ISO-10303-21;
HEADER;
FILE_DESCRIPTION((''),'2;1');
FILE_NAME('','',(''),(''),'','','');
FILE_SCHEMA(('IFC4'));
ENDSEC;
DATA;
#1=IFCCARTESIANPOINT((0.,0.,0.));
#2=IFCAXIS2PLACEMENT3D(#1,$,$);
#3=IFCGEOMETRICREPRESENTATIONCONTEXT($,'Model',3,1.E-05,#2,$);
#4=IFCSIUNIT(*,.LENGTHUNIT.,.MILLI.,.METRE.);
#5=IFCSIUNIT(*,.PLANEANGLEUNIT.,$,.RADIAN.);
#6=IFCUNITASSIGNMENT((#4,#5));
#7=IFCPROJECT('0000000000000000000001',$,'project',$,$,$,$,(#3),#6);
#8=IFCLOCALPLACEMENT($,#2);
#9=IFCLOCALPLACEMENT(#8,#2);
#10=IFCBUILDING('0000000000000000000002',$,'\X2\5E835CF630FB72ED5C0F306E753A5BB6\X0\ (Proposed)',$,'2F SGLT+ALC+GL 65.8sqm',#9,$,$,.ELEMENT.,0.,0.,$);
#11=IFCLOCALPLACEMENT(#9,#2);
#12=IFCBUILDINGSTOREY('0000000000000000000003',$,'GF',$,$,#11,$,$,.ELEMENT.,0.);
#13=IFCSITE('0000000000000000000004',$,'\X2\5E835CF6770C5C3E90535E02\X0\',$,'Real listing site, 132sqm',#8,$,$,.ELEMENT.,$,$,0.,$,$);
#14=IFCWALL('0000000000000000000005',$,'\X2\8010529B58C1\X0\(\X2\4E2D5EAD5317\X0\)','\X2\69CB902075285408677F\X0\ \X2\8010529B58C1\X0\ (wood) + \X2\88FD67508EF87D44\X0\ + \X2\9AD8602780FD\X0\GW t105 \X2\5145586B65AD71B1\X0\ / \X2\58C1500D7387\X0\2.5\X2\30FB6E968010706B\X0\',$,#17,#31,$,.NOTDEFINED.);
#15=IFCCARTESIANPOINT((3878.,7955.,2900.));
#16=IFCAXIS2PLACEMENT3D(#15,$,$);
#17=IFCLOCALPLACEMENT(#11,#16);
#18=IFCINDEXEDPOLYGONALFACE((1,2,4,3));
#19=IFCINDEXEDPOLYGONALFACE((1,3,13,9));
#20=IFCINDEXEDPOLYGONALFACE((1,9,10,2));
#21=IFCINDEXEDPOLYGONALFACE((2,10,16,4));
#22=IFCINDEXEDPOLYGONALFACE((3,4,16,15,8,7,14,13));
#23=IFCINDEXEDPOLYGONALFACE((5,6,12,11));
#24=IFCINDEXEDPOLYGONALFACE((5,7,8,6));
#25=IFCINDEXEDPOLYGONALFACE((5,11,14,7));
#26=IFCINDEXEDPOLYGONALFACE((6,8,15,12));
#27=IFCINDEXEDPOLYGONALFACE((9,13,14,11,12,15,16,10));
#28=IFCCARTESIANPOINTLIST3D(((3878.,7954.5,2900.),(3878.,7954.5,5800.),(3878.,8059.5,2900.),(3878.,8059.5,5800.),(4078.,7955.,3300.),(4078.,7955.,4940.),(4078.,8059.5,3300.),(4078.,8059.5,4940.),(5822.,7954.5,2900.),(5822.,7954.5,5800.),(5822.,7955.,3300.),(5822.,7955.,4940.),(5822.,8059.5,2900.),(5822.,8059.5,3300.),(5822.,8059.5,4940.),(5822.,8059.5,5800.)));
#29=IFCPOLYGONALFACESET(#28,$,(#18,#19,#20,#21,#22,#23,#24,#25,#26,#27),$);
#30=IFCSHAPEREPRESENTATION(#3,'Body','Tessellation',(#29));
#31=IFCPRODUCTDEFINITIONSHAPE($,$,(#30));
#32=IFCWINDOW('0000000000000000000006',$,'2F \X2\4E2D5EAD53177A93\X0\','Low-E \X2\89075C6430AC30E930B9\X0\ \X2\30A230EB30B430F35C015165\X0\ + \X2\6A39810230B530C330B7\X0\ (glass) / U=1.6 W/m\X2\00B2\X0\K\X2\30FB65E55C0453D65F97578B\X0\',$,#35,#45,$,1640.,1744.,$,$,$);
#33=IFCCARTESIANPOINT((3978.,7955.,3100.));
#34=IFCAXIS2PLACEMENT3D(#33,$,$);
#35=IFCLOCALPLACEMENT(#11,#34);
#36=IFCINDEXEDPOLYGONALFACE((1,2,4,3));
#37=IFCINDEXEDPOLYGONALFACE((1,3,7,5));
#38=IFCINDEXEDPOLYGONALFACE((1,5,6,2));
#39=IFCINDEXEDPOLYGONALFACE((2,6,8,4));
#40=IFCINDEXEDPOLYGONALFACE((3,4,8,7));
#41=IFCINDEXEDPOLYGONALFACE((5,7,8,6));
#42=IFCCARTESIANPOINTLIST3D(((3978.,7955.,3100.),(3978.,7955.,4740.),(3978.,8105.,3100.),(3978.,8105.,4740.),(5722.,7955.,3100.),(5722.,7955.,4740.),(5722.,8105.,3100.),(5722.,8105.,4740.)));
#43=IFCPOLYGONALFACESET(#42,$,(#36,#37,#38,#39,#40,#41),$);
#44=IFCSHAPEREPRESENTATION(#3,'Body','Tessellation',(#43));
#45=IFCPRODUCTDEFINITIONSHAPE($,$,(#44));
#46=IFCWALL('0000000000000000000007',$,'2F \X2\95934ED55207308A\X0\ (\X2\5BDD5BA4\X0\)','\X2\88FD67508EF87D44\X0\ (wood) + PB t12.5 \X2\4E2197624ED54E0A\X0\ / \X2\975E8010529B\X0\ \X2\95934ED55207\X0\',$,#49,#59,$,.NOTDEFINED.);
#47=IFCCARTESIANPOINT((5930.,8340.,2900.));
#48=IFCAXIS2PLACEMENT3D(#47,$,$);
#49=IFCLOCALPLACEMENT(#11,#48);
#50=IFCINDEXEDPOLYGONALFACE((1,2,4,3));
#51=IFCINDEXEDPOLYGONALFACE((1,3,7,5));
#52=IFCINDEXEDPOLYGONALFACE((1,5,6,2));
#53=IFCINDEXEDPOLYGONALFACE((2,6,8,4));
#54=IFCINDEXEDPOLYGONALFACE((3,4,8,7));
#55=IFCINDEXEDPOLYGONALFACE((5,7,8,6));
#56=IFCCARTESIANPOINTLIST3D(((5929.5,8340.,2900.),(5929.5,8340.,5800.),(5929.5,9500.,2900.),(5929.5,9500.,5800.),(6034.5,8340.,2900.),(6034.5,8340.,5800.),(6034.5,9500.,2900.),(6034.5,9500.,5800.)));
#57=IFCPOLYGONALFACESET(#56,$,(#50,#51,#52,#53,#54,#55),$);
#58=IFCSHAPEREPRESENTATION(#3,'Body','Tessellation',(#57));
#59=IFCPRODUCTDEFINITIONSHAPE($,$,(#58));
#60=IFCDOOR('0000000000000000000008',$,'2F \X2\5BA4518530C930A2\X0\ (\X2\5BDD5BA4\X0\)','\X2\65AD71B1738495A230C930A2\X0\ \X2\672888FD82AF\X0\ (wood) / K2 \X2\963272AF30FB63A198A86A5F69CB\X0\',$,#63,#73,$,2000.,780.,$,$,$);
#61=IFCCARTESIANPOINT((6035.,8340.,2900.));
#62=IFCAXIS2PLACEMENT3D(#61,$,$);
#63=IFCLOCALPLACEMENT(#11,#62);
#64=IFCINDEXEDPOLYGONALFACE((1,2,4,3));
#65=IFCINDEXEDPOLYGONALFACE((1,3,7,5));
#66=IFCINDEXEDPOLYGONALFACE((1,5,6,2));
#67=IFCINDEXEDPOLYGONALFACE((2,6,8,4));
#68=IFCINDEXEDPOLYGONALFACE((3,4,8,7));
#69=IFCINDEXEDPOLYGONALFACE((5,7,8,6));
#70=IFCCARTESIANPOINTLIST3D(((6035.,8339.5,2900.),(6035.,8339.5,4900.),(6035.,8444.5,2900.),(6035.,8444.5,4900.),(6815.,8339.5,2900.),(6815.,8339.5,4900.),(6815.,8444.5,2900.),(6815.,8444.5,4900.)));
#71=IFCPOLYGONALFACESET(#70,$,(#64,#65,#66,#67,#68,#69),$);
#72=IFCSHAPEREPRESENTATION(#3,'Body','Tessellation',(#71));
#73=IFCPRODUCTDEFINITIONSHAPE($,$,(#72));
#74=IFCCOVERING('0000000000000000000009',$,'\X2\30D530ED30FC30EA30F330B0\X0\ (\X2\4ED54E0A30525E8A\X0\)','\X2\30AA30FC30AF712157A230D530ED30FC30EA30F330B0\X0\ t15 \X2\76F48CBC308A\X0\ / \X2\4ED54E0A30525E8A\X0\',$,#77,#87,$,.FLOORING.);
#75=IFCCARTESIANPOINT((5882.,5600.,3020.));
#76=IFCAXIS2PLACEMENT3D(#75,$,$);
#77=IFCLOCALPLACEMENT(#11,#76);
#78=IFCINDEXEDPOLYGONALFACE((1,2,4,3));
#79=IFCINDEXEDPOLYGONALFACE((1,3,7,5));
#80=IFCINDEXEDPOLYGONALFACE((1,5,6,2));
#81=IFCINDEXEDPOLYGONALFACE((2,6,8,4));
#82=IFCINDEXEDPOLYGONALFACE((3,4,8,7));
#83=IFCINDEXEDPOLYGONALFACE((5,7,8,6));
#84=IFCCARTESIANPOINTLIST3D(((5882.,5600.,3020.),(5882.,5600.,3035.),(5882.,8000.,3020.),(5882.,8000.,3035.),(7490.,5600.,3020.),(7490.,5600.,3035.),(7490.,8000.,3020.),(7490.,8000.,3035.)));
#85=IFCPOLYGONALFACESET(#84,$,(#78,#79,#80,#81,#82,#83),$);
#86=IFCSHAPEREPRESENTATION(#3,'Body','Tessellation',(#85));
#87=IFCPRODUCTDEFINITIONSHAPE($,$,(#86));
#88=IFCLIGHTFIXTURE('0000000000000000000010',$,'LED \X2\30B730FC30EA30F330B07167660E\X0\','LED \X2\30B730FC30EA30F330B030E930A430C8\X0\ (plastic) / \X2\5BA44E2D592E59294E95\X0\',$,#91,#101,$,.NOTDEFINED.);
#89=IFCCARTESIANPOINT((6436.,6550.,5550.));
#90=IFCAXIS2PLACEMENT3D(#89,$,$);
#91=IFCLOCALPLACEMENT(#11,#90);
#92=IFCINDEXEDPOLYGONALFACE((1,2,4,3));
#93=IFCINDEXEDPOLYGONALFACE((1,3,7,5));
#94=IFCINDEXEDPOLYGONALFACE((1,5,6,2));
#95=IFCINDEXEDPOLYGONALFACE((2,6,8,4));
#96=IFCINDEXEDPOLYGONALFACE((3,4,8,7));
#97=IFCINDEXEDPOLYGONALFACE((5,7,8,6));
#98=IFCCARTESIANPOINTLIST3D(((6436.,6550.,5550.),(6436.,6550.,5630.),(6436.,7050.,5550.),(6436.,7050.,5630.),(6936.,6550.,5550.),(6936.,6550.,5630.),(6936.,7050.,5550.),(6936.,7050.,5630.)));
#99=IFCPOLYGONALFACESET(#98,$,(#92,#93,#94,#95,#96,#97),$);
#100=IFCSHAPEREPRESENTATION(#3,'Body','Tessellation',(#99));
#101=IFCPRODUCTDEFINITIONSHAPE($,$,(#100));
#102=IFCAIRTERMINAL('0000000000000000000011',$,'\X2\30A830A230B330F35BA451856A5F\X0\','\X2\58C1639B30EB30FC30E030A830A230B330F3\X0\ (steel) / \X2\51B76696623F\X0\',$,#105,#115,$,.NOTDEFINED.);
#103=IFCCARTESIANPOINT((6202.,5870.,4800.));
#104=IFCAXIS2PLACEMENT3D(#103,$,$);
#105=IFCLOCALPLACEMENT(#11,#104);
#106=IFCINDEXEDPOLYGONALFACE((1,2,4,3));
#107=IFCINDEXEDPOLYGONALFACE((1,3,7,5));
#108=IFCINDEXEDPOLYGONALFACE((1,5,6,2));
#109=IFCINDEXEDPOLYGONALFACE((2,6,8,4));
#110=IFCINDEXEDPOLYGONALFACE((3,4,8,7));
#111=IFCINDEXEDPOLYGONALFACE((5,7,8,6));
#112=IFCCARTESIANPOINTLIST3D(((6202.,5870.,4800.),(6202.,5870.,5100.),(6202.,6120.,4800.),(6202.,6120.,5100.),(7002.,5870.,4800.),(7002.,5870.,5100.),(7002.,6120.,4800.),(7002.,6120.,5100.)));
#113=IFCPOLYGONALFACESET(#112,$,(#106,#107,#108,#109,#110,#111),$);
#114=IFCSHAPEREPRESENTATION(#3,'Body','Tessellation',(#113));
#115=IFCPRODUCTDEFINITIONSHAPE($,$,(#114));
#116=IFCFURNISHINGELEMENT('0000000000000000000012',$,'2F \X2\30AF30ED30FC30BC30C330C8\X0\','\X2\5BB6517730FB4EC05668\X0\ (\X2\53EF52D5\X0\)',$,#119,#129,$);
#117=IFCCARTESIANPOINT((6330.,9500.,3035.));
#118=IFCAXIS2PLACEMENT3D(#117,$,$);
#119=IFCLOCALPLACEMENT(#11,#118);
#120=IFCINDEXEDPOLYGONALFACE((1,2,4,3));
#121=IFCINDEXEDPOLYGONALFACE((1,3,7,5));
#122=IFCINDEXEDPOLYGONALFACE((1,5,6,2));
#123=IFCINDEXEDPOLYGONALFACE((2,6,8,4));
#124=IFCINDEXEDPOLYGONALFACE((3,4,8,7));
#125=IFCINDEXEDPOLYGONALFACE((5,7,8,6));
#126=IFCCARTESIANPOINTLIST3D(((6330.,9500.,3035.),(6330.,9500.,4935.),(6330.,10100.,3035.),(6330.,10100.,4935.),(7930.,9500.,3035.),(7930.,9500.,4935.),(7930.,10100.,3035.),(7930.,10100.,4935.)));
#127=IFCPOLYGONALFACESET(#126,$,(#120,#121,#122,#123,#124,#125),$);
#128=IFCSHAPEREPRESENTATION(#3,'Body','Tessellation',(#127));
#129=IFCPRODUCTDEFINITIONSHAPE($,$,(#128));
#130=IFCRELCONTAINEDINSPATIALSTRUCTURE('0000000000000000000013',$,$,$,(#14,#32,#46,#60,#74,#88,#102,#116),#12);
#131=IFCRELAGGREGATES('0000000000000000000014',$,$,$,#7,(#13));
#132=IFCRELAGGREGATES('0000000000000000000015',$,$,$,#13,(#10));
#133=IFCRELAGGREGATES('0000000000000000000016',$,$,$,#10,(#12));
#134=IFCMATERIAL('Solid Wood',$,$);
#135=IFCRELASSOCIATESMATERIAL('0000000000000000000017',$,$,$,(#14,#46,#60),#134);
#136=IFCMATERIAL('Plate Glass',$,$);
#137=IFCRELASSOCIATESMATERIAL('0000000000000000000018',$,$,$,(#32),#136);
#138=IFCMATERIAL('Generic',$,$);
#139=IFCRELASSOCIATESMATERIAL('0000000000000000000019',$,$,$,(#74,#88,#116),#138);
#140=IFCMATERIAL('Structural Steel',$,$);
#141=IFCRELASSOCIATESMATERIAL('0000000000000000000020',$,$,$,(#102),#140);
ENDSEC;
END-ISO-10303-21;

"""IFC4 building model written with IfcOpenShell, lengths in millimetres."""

from ifc_helpers import new_model, si_unit, frame, frame_2d, origin, place, context, project, spatial, rectangle, extrude, material, element, fill, save


model = new_model("IFC4")

# Units and contexts
model_context = context("Model", 3, precision=1e-05, world=origin())
ifc_project = project(units=[si_unit("LENGTHUNIT", "METRE", prefix="MILLI"), si_unit("PLANEANGLEUNIT", "RADIAN")], contexts=[model_context])

# Site, building, storey
site_placement = place(None, origin())
site = spatial("IfcSite", under=ifc_project, at=site_placement, Name="広島県尾道市", ObjectType="Real listing site, 132sqm", CompositionType="ELEMENT", RefElevation=0.0)
building_placement = place(site_placement, origin())
building = spatial("IfcBuilding", under=site, at=building_placement, Name="広島・狭小の町家 (Proposed)", ObjectType="2F SGLT+ALC+GL 65.8sqm", CompositionType="ELEMENT", ElevationOfRefHeight=0.0, ElevationOfTerrain=0.0)
storey_placement = place(building_placement, origin())
storey = spatial("IfcBuildingStorey", under=building, at=storey_placement, Name="GF", CompositionType="ELEMENT", Elevation=0.0)

# Shared definitions
ifc_material_1 = material(Name="Solid Wood")

# Wall, opening, window
wall_1_placement = place(storey_placement, frame((3878.0, 7955.0, 2900.0)))
wall_1 = element("IfcWall", 1, at=wall_1_placement, inside=storey, material=ifc_material_1, Name="耐力壁(中庭北)", Description="構造用合板 耐力壁 (wood) + 製材軸組 + 高性能GW t105 充填断熱 / 壁倍率2.5・準耐火", PredefinedType="NOTDEFINED", context=model_context, shape_type="SweptSolid", body=[
    extrude(rectangle(XDim=1944.0, YDim=105.0, at=frame_2d((972.0, 52.0))), frame((3878.0, 7955.0, 2900.0)), (0.0, 0.0, 1.0), 2900.0),
])
opening_placement = place(storey_placement, frame((3978.0, 7955.0, 3100.0)))
opening = element("IfcOpeningElement", 2, at=opening_placement, cuts=wall_1, PredefinedType="NOTDEFINED", context=model_context, shape_type="SweptSolid", body=[
    extrude(rectangle(XDim=1744.0, YDim=150.0, at=frame_2d((872.0, 75.0))), frame((3978.0, 7955.0, 3100.0)), (0.0, 0.0, 1.0), 1640.0),
])
ifc_material_2 = material(Name="Plate Glass")
window_placement = place(storey_placement, frame((3978.0, 7955.0, 3100.0)))
window = element("IfcWindow", 3, at=window_placement, inside=storey, material=ifc_material_2, Name="2F 中庭北窓", Description="Low-E 複層ガラス アルゴン封入 + 樹脂サッシ (glass) / U=1.6 W/m²K・日射取得型", OverallHeight=1640.0, OverallWidth=1744.0, context=model_context, shape_type="SweptSolid", body=[
    extrude(rectangle(XDim=1744.0, YDim=150.0, at=frame_2d((872.0, 75.0))), frame((3978.0, 7955.0, 3100.0)), (0.0, 0.0, 1.0), 1640.0),
])
fill(opening, window)

# Wall
wall_2_placement = place(storey_placement, frame((5930.0, 8340.0, 2900.0)))
element("IfcWall", 4, at=wall_2_placement, inside=storey, material=ifc_material_1, Name="2F 間仕切り (寝室)", Description="製材軸組 (wood) + PB t12.5 両面仕上 / 非耐力 間仕切", PredefinedType="NOTDEFINED", context=model_context, shape_type="SweptSolid", body=[
    extrude(rectangle(XDim=105.0, YDim=1160.0, at=frame_2d((52.0, 580.0))), frame((5930.0, 8340.0, 2900.0)), (0.0, 0.0, 1.0), 2900.0),
])

# Door
door_placement = place(storey_placement, frame((6035.0, 8340.0, 2900.0)))
element("IfcDoor", 5, at=door_placement, inside=storey, material=ifc_material_1, Name="2F 室内ドア (寝室)", Description="断熱玄関ドア 木製芯 (wood) / K2 防犯・採風機構", OverallHeight=2000.0, OverallWidth=780.0, context=model_context, shape_type="SweptSolid", body=[
    extrude(rectangle(XDim=780.0, YDim=105.0, at=frame_2d((390.0, 52.0))), frame((6035.0, 8340.0, 2900.0)), (0.0, 0.0, 1.0), 2000.0),
])

# Covering
ifc_material_3 = material(Name="Generic")
covering_placement = place(storey_placement, frame((5882.0, 5600.0, 3020.0)))
element("IfcCovering", 6, at=covering_placement, inside=storey, material=ifc_material_3, Name="フローリング (仕上げ床)", Description="オーク無垢フローリング t15 直貼り / 仕上げ床", PredefinedType="FLOORING", context=model_context, shape_type="SweptSolid", body=[
    extrude(rectangle(XDim=1608.0, YDim=2400.0, at=frame_2d((804.0, 1200.0))), frame((5882.0, 5600.0, 3020.0)), (0.0, 0.0, 1.0), 15.0),
])

# Light fixture
light_fixture_placement = place(storey_placement, frame((6436.0, 6550.0, 5550.0)))
element("IfcLightFixture", 7, at=light_fixture_placement, inside=storey, material=ifc_material_3, Name="LED シーリング照明", Description="LED シーリングライト (plastic) / 室中央天井", PredefinedType="NOTDEFINED", context=model_context, shape_type="SweptSolid", body=[
    extrude(rectangle(XDim=500.0, YDim=500.0, at=frame_2d((250.0, 250.0))), frame((6436.0, 6550.0, 5550.0)), (0.0, 0.0, 1.0), 80.0),
])

# Air terminal
ifc_material_4 = material(Name="Structural Steel")
air_terminal_placement = place(storey_placement, frame((6202.0, 5870.0, 4800.0)))
element("IfcAirTerminal", 8, at=air_terminal_placement, inside=storey, material=ifc_material_4, Name="エアコン室内機", Description="壁掛ルームエアコン (steel) / 冷暖房", PredefinedType="NOTDEFINED", context=model_context, shape_type="SweptSolid", body=[
    extrude(rectangle(XDim=800.0, YDim=250.0, at=frame_2d((400.0, 125.0))), frame((6202.0, 5870.0, 4800.0)), (0.0, 0.0, 1.0), 300.0),
])

# Furnishing element
furnishing_placement = place(storey_placement, frame((6330.0, 9500.0, 3035.0)))
element("IfcFurnishingElement", 9, at=furnishing_placement, inside=storey, material=ifc_material_3, Name="2F クローゼット", Description="家具・什器 (可動)", context=model_context, shape_type="SweptSolid", body=[
    extrude(rectangle(XDim=1600.0, YDim=600.0, at=frame_2d((800.0, 300.0))), frame((6330.0, 9500.0, 3035.0)), (0.0, 0.0, 1.0), 1900.0),
])

save(model, "model.ifc")
